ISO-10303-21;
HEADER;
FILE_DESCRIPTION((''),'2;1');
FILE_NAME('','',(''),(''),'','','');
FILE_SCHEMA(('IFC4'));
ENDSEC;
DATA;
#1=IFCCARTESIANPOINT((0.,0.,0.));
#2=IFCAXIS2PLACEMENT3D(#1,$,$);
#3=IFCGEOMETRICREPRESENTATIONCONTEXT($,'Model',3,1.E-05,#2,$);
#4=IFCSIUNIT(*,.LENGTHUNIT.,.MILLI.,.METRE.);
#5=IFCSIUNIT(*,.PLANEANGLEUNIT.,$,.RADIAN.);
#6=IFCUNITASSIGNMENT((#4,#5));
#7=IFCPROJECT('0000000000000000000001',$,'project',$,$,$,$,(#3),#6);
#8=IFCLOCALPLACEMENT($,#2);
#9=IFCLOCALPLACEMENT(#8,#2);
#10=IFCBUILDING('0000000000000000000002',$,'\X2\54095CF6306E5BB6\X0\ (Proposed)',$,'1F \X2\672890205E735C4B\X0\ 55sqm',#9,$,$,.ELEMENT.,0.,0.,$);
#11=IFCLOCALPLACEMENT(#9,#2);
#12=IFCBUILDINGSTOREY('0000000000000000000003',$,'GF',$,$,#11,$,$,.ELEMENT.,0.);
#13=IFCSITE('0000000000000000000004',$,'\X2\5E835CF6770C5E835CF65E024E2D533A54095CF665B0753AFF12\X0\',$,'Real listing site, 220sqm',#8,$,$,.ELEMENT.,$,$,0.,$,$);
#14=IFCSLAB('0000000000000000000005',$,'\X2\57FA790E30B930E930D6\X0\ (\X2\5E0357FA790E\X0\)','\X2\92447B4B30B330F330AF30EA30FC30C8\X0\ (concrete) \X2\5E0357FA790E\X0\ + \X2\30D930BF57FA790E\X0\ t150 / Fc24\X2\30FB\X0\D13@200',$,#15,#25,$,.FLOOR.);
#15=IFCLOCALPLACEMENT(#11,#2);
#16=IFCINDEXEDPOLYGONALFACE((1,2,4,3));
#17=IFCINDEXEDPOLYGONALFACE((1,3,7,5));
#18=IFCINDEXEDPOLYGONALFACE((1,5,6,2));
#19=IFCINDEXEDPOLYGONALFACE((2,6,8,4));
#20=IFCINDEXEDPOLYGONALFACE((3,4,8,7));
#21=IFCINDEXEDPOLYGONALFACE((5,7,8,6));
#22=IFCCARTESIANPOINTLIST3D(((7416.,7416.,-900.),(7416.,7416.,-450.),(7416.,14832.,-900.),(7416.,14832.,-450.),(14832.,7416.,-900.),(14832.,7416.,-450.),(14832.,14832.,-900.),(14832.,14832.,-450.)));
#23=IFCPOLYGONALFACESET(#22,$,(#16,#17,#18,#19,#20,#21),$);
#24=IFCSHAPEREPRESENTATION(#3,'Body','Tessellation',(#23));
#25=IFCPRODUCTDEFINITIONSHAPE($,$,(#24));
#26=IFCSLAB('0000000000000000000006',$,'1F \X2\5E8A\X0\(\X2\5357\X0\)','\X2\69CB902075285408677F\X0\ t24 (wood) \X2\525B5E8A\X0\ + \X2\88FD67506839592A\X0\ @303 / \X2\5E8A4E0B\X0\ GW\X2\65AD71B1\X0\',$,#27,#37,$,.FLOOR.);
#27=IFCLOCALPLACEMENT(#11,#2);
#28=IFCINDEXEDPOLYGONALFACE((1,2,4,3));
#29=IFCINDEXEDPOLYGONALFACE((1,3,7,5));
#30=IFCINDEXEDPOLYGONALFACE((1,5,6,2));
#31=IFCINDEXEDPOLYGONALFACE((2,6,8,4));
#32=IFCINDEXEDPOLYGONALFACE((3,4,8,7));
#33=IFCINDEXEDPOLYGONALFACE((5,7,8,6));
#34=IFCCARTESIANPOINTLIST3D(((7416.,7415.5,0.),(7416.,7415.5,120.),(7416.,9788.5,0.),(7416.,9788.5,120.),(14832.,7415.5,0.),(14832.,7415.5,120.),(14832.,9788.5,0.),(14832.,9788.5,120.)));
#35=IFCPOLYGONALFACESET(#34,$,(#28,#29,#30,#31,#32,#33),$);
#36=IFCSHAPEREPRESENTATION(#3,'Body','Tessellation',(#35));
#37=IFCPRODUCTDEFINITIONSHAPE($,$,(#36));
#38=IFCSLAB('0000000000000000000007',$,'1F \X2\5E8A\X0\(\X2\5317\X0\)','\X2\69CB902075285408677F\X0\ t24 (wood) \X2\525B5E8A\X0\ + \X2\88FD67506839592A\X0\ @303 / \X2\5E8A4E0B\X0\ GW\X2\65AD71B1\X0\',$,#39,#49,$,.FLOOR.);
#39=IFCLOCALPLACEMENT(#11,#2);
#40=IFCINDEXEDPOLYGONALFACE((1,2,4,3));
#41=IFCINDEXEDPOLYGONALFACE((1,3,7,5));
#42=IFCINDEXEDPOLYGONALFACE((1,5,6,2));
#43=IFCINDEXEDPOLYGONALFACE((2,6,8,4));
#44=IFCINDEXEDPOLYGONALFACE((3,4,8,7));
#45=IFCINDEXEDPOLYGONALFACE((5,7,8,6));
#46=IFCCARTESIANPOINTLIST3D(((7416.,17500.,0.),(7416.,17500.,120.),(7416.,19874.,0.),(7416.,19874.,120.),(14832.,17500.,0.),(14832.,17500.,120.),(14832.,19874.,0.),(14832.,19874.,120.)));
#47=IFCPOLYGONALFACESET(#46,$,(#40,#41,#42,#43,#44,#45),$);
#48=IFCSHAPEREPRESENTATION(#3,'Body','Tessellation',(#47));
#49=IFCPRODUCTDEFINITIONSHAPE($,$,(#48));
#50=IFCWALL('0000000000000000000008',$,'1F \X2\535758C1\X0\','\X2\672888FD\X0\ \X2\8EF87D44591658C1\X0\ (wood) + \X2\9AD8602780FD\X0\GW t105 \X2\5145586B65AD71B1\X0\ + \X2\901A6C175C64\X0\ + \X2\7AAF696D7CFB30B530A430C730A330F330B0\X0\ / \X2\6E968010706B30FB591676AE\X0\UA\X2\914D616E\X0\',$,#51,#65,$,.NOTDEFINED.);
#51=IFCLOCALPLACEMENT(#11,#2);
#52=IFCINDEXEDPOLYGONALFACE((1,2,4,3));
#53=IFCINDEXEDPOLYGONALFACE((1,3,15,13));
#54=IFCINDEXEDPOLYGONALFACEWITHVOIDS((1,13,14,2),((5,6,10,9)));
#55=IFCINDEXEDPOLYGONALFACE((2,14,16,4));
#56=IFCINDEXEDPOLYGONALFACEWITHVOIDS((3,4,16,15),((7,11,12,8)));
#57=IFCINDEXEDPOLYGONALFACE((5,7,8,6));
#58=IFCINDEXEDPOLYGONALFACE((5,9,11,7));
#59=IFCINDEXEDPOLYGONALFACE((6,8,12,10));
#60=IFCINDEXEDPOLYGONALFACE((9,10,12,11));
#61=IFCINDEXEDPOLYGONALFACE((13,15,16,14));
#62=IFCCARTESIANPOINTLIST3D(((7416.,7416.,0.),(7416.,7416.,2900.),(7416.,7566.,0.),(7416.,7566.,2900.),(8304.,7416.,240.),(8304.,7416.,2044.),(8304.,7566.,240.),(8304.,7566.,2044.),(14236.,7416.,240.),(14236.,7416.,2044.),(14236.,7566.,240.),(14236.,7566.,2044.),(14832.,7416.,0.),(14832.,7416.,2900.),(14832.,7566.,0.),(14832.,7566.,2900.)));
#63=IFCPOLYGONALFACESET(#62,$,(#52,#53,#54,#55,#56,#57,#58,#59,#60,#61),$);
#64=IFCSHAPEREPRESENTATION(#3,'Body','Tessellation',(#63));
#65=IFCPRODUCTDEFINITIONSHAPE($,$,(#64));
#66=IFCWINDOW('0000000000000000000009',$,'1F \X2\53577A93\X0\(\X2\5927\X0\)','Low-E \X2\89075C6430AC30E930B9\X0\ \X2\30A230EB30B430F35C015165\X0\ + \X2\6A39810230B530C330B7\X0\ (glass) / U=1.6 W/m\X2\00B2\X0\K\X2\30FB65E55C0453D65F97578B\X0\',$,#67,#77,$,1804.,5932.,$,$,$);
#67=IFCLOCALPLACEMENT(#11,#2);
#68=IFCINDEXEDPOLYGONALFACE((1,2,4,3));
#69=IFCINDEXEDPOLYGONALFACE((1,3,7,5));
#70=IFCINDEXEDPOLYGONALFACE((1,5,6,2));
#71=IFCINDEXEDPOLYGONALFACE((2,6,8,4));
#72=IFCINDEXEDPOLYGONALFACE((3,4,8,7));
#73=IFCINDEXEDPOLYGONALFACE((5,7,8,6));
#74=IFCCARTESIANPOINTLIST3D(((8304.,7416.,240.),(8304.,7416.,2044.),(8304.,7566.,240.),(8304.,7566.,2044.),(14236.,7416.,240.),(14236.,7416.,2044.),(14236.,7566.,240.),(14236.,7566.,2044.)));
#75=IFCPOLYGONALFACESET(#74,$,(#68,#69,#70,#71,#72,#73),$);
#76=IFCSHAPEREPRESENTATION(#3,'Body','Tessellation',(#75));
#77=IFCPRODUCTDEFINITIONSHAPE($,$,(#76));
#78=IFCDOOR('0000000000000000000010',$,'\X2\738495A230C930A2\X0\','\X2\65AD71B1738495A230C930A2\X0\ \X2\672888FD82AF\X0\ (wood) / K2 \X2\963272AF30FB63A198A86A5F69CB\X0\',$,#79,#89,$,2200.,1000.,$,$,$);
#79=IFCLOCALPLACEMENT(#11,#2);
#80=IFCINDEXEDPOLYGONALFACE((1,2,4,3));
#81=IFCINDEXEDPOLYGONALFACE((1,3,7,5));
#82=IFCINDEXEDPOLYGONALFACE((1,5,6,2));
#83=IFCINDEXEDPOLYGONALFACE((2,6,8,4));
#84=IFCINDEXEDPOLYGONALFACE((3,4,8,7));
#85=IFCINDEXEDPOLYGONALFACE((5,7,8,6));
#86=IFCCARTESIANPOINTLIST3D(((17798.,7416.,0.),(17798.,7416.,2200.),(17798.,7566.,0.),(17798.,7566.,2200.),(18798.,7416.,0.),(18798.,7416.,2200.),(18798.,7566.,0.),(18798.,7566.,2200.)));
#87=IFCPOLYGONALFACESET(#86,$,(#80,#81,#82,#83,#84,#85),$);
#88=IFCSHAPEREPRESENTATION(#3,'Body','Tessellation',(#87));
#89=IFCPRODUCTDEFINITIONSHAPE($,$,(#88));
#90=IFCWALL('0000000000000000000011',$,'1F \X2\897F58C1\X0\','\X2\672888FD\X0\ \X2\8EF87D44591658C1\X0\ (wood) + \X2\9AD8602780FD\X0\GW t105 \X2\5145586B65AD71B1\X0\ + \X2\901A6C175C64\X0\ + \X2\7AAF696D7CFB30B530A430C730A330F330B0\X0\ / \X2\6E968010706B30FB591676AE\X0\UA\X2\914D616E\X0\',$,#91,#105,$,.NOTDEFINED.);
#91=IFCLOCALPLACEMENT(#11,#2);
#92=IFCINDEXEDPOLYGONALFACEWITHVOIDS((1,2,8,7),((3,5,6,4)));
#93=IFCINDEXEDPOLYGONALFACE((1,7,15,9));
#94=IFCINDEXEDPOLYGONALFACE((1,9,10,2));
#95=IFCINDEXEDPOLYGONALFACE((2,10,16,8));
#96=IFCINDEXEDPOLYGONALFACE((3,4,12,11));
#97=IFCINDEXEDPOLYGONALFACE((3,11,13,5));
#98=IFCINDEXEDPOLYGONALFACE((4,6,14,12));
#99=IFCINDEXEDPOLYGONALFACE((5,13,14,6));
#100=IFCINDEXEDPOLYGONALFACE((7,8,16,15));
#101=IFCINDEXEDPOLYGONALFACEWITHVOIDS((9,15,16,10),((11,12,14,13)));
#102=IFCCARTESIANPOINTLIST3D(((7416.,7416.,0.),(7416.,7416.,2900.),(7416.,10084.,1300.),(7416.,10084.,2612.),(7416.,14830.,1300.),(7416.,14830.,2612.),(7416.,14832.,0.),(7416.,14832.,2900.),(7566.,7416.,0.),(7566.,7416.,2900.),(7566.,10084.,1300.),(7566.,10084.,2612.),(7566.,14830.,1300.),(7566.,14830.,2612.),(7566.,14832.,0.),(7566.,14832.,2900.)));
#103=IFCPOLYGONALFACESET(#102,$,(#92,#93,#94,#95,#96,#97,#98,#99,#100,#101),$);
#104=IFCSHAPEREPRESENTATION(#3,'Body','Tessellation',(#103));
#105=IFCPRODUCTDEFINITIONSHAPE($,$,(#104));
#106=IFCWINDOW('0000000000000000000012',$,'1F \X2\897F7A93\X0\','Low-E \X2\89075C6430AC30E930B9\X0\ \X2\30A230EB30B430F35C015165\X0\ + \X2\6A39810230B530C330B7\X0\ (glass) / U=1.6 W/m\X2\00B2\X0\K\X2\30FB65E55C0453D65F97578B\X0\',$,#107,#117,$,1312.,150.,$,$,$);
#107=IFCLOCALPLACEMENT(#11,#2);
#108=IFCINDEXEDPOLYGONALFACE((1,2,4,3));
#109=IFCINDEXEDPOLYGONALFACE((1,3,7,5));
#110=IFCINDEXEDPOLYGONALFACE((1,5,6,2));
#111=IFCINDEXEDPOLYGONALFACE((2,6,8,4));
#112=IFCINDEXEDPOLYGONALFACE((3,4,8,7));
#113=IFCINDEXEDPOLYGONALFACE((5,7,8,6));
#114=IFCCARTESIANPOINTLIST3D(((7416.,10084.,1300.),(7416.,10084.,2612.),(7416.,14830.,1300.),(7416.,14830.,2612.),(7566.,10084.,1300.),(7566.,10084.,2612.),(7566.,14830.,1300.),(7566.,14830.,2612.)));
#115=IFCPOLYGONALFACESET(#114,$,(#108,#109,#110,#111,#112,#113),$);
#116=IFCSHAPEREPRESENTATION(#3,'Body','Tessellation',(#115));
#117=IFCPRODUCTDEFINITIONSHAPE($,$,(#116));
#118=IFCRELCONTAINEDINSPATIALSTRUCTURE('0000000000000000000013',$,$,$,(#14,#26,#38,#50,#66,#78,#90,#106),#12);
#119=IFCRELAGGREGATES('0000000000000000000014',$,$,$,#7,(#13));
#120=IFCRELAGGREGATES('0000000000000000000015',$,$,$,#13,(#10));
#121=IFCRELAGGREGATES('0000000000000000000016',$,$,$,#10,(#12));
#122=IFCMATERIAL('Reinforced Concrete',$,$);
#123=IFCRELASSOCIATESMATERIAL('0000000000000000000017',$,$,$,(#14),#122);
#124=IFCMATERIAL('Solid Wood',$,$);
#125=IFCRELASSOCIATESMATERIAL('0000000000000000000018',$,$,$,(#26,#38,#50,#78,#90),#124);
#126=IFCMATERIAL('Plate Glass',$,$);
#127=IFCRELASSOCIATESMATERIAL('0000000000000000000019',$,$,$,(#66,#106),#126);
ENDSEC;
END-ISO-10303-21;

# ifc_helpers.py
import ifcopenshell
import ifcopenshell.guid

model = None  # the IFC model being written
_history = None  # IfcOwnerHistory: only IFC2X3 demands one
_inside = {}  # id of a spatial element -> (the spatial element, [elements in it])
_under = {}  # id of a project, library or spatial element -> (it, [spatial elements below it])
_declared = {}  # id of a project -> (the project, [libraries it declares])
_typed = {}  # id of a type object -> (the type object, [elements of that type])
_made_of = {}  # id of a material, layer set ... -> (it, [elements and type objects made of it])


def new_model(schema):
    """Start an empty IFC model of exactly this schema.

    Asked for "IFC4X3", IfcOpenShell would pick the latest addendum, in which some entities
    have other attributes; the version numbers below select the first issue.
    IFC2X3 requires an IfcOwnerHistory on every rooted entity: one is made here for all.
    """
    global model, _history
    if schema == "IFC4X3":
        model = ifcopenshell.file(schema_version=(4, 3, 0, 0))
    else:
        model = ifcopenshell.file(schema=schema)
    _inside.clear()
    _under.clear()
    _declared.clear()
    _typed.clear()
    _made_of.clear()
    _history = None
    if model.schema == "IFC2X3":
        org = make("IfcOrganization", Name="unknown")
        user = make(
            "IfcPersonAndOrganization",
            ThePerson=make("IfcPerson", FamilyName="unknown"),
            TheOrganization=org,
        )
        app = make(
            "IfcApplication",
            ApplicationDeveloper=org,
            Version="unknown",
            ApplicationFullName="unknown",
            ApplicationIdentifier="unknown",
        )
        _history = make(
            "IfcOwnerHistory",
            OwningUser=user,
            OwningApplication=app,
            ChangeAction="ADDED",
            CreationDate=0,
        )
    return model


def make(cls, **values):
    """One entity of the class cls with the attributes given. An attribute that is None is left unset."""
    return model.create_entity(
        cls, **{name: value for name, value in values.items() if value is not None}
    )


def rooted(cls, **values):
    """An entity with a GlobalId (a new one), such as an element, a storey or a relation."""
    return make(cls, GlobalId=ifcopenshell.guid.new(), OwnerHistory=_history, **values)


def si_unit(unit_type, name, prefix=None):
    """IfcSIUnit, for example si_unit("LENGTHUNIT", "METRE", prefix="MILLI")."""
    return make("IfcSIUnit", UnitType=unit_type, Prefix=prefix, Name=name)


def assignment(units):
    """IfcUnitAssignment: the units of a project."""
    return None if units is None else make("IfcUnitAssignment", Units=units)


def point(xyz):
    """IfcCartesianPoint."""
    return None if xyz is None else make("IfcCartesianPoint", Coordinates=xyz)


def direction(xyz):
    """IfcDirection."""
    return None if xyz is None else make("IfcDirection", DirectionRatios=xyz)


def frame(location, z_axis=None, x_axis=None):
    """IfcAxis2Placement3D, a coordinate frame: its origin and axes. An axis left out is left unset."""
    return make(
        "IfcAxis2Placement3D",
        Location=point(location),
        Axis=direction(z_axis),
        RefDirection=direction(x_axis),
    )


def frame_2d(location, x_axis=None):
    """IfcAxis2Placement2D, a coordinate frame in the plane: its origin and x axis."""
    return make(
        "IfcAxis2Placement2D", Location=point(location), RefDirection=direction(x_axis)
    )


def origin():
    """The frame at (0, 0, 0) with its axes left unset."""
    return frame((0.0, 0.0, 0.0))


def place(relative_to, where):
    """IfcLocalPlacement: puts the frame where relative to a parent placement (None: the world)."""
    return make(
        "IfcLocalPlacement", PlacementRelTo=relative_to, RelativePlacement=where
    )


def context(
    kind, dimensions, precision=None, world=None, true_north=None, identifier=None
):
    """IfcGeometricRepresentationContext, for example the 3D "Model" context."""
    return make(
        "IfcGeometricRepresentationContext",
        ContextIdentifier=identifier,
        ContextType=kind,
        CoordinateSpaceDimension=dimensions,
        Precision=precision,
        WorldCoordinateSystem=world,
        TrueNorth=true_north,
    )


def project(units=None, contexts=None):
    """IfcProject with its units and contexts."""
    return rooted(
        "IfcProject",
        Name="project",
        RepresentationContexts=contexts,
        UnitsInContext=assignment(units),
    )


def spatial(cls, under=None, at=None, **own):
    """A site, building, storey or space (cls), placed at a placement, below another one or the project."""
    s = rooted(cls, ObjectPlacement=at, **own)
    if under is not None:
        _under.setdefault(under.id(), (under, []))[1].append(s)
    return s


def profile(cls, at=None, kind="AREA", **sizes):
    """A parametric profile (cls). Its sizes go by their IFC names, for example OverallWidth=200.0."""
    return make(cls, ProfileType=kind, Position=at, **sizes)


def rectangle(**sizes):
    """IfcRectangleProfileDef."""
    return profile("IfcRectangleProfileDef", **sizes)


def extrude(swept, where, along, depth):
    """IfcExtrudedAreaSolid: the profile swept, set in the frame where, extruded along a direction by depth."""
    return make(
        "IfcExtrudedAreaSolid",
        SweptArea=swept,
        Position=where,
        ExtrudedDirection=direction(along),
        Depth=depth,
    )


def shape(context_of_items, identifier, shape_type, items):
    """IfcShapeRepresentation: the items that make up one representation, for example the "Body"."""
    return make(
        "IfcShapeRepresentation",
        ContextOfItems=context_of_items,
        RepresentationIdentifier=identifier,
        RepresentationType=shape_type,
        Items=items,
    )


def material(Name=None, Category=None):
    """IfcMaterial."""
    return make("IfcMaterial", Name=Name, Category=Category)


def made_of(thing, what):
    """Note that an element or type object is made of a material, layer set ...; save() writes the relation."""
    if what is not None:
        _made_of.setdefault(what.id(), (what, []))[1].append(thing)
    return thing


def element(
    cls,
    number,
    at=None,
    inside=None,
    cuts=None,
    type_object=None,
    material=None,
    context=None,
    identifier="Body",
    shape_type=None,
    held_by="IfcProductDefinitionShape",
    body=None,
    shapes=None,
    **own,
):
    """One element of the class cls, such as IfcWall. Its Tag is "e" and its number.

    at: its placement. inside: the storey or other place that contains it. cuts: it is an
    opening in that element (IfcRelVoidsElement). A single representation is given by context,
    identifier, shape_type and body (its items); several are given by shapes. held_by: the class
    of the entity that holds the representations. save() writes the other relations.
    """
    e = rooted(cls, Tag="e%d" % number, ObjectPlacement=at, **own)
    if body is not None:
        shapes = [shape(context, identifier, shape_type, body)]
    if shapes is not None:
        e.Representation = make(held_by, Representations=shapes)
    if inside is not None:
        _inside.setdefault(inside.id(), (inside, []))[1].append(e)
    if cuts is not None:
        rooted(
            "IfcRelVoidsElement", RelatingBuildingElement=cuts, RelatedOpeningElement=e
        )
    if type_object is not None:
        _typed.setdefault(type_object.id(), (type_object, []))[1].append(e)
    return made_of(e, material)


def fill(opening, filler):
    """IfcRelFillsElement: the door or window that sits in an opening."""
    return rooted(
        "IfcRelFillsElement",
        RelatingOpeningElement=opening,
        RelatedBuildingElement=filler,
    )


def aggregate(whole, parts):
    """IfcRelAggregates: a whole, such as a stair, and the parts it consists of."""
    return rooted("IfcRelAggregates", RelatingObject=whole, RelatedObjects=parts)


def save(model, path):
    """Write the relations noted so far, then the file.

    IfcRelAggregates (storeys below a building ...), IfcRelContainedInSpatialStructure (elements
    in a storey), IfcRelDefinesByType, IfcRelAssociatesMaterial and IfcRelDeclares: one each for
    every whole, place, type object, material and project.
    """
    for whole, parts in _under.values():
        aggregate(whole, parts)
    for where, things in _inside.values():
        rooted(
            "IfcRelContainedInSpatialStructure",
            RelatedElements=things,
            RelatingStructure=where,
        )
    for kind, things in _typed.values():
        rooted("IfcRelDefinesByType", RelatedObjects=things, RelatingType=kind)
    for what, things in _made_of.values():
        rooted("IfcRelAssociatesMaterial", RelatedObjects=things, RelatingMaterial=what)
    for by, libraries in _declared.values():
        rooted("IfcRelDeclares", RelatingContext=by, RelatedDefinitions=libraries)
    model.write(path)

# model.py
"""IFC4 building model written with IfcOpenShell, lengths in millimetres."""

from ifc_helpers import new_model, si_unit, frame, frame_2d, origin, place, context, project, spatial, rectangle, extrude, material, element, fill, save


model = new_model("IFC4")

# Units and contexts
model_context = context("Model", 3, precision=1e-05, world=origin())
ifc_project = project(units=[si_unit("LENGTHUNIT", "METRE", prefix="MILLI"), si_unit("PLANEANGLEUNIT", "RADIAN")], contexts=[model_context])

# Site, building, storey
site_placement = place(None, origin())
site = spatial("IfcSite", under=ifc_project, at=site_placement, Name="広島県広島市中区吉島新町２", ObjectType="Real listing site, 220sqm", CompositionType="ELEMENT", RefElevation=0.0)
building_placement = place(site_placement, origin())
building = spatial("IfcBuilding", under=site, at=building_placement, Name="吉島の家 (Proposed)", ObjectType="1F 木造平屋 55sqm", CompositionType="ELEMENT", ElevationOfRefHeight=0.0, ElevationOfTerrain=0.0)
storey_placement = place(building_placement, origin())
storey = spatial("IfcBuildingStorey", under=building, at=storey_placement, Name="GF", CompositionType="ELEMENT", Elevation=0.0)

# Slabs
ifc_material_1 = material(Name="Reinforced Concrete")
slab_1_placement = place(storey_placement, frame((3708.0, 3708.0, -450.0)))
element("IfcSlab", 1, at=slab_1_placement, inside=storey, material=ifc_material_1, Name="基礎スラブ (布基礎)", Description="鉄筋コンクリート (concrete) 布基礎 + ベタ基礎 t150 / Fc24・D13@200", PredefinedType="FLOOR", context=model_context, shape_type="SweptSolid", body=[
    extrude(rectangle(XDim=7416.0, YDim=7416.0, at=frame_2d((3708.0, 3708.0))), frame((3708.0, 3708.0, -450.0)), (0.0, 0.0, 1.0), 450.0),
])
ifc_material_2 = material(Name="Solid Wood")
slab_2_placement = place(storey_placement, frame((3708.0, 3708.0, 0.0)))
element("IfcSlab", 2, at=slab_2_placement, inside=storey, material=ifc_material_2, Name="1F 床(南)", Description="構造用合板 t24 (wood) 剛床 + 製材根太 @303 / 床下 GW断熱", PredefinedType="FLOOR", context=model_context, shape_type="SweptSolid", body=[
    extrude(rectangle(XDim=7416.0, YDim=2373.0, at=frame_2d((3708.0, 1186.0))), frame((3708.0, 3708.0, 0.0)), (0.0, 0.0, 1.0), 120.0),
])
slab_3_placement = place(storey_placement, frame((3708.0, 8750.0, 0.0)))
element("IfcSlab", 3, at=slab_3_placement, inside=storey, material=ifc_material_2, Name="1F 床(北)", Description="構造用合板 t24 (wood) 剛床 + 製材根太 @303 / 床下 GW断熱", PredefinedType="FLOOR", context=model_context, shape_type="SweptSolid", body=[
    extrude(rectangle(XDim=7416.0, YDim=2374.0, at=frame_2d((3708.0, 1187.0))), frame((3708.0, 8750.0, 0.0)), (0.0, 0.0, 1.0), 120.0),
])

# Wall, openings, window, door
wall_1_placement = place(storey_placement, frame((3708.0, 3708.0, 0.0)))
wall_1 = element("IfcWall", 4, at=wall_1_placement, inside=storey, material=ifc_material_2, Name="1F 南壁", Description="木製 軸組外壁 (wood) + 高性能GW t105 充填断熱 + 通気層 + 窯業系サイディング / 準耐火・外皮UA配慮", PredefinedType="NOTDEFINED", context=model_context, shape_type="SweptSolid", body=[
    extrude(rectangle(XDim=7416.0, YDim=150.0, at=frame_2d((3708.0, 75.0))), frame((3708.0, 3708.0, 0.0)), (0.0, 0.0, 1.0), 2900.0),
])
opening_1_placement = place(storey_placement, frame((4152.0, 3708.0, 120.0)))
opening_1 = element("IfcOpeningElement", 5, at=opening_1_placement, cuts=wall_1, PredefinedType="NOTDEFINED", context=model_context, shape_type="SweptSolid", body=[
    extrude(rectangle(XDim=5932.0, YDim=150.0, at=frame_2d((2966.0, 75.0))), frame((4152.0, 3708.0, 120.0)), (0.0, 0.0, 1.0), 1804.0),
])
opening_2_placement = place(storey_placement, frame((8899.0, 3708.0, 0.0)))
opening_2 = element("IfcOpeningElement", 6, at=opening_2_placement, cuts=wall_1, PredefinedType="NOTDEFINED", context=model_context, shape_type="SweptSolid", body=[
    extrude(rectangle(XDim=1000.0, YDim=150.0, at=frame_2d((500.0, 75.0))), frame((8899.0, 3708.0, 0.0)), (0.0, 0.0, 1.0), 2200.0),
])
ifc_material_3 = material(Name="Plate Glass")
window_1_placement = place(storey_placement, frame((4152.0, 3708.0, 120.0)))
window_1 = element("IfcWindow", 7, at=window_1_placement, inside=storey, material=ifc_material_3, Name="1F 南窓(大)", Description="Low-E 複層ガラス アルゴン封入 + 樹脂サッシ (glass) / U=1.6 W/m²K・日射取得型", OverallHeight=1804.0, OverallWidth=5932.0, context=model_context, shape_type="SweptSolid", body=[
    extrude(rectangle(XDim=5932.0, YDim=150.0, at=frame_2d((2966.0, 75.0))), frame((4152.0, 3708.0, 120.0)), (0.0, 0.0, 1.0), 1804.0),
])
fill(opening_1, window_1)
door_1_placement = place(storey_placement, frame((8899.0, 3708.0, 0.0)))
door_1 = element("IfcDoor", 8, at=door_1_placement, inside=storey, material=ifc_material_2, Name="玄関ドア", Description="断熱玄関ドア 木製芯 (wood) / K2 防犯・採風機構", OverallHeight=2200.0, OverallWidth=1000.0, context=model_context, shape_type="SweptSolid", body=[
    extrude(rectangle(XDim=1000.0, YDim=150.0, at=frame_2d((500.0, 75.0))), frame((8899.0, 3708.0, 0.0)), (0.0, 0.0, 1.0), 2200.0),
])
fill(opening_2, door_1)

# Wall, opening, window
wall_2_placement = place(storey_placement, frame((3708.0, 3708.0, 0.0)))
wall_2 = element("IfcWall", 9, at=wall_2_placement, inside=storey, material=ifc_material_2, Name="1F 西壁", Description="木製 軸組外壁 (wood) + 高性能GW t105 充填断熱 + 通気層 + 窯業系サイディング / 準耐火・外皮UA配慮", PredefinedType="NOTDEFINED", context=model_context, shape_type="SweptSolid", body=[
    extrude(rectangle(XDim=150.0, YDim=7416.0, at=frame_2d((75.0, 3708.0))), frame((3708.0, 3708.0, 0.0)), (0.0, 0.0, 1.0), 2900.0),
])
opening_3_placement = place(storey_placement, frame((3708.0, 5042.0, 650.0)))
opening_3 = element("IfcOpeningElement", 10, at=opening_3_placement, cuts=wall_2, PredefinedType="NOTDEFINED", context=model_context, shape_type="SweptSolid", body=[
    extrude(rectangle(XDim=150.0, YDim=4746.0, at=frame_2d((75.0, 2373.0))), frame((3708.0, 5042.0, 650.0)), (0.0, 0.0, 1.0), 1312.0),
])
window_2_placement = place(storey_placement, frame((3708.0, 5042.0, 650.0)))
window_2 = element("IfcWindow", 11, at=window_2_placement, inside=storey, material=ifc_material_3, Name="1F 西窓", Description="Low-E 複層ガラス アルゴン封入 + 樹脂サッシ (glass) / U=1.6 W/m²K・日射取得型", OverallHeight=1312.0, OverallWidth=150.0, context=model_context, shape_type="SweptSolid", body=[
    extrude(rectangle(XDim=150.0, YDim=4746.0, at=frame_2d((75.0, 2373.0))), frame((3708.0, 5042.0, 650.0)), (0.0, 0.0, 1.0), 1312.0),
])
fill(opening_3, window_2)

save(model, "model.ifc")
